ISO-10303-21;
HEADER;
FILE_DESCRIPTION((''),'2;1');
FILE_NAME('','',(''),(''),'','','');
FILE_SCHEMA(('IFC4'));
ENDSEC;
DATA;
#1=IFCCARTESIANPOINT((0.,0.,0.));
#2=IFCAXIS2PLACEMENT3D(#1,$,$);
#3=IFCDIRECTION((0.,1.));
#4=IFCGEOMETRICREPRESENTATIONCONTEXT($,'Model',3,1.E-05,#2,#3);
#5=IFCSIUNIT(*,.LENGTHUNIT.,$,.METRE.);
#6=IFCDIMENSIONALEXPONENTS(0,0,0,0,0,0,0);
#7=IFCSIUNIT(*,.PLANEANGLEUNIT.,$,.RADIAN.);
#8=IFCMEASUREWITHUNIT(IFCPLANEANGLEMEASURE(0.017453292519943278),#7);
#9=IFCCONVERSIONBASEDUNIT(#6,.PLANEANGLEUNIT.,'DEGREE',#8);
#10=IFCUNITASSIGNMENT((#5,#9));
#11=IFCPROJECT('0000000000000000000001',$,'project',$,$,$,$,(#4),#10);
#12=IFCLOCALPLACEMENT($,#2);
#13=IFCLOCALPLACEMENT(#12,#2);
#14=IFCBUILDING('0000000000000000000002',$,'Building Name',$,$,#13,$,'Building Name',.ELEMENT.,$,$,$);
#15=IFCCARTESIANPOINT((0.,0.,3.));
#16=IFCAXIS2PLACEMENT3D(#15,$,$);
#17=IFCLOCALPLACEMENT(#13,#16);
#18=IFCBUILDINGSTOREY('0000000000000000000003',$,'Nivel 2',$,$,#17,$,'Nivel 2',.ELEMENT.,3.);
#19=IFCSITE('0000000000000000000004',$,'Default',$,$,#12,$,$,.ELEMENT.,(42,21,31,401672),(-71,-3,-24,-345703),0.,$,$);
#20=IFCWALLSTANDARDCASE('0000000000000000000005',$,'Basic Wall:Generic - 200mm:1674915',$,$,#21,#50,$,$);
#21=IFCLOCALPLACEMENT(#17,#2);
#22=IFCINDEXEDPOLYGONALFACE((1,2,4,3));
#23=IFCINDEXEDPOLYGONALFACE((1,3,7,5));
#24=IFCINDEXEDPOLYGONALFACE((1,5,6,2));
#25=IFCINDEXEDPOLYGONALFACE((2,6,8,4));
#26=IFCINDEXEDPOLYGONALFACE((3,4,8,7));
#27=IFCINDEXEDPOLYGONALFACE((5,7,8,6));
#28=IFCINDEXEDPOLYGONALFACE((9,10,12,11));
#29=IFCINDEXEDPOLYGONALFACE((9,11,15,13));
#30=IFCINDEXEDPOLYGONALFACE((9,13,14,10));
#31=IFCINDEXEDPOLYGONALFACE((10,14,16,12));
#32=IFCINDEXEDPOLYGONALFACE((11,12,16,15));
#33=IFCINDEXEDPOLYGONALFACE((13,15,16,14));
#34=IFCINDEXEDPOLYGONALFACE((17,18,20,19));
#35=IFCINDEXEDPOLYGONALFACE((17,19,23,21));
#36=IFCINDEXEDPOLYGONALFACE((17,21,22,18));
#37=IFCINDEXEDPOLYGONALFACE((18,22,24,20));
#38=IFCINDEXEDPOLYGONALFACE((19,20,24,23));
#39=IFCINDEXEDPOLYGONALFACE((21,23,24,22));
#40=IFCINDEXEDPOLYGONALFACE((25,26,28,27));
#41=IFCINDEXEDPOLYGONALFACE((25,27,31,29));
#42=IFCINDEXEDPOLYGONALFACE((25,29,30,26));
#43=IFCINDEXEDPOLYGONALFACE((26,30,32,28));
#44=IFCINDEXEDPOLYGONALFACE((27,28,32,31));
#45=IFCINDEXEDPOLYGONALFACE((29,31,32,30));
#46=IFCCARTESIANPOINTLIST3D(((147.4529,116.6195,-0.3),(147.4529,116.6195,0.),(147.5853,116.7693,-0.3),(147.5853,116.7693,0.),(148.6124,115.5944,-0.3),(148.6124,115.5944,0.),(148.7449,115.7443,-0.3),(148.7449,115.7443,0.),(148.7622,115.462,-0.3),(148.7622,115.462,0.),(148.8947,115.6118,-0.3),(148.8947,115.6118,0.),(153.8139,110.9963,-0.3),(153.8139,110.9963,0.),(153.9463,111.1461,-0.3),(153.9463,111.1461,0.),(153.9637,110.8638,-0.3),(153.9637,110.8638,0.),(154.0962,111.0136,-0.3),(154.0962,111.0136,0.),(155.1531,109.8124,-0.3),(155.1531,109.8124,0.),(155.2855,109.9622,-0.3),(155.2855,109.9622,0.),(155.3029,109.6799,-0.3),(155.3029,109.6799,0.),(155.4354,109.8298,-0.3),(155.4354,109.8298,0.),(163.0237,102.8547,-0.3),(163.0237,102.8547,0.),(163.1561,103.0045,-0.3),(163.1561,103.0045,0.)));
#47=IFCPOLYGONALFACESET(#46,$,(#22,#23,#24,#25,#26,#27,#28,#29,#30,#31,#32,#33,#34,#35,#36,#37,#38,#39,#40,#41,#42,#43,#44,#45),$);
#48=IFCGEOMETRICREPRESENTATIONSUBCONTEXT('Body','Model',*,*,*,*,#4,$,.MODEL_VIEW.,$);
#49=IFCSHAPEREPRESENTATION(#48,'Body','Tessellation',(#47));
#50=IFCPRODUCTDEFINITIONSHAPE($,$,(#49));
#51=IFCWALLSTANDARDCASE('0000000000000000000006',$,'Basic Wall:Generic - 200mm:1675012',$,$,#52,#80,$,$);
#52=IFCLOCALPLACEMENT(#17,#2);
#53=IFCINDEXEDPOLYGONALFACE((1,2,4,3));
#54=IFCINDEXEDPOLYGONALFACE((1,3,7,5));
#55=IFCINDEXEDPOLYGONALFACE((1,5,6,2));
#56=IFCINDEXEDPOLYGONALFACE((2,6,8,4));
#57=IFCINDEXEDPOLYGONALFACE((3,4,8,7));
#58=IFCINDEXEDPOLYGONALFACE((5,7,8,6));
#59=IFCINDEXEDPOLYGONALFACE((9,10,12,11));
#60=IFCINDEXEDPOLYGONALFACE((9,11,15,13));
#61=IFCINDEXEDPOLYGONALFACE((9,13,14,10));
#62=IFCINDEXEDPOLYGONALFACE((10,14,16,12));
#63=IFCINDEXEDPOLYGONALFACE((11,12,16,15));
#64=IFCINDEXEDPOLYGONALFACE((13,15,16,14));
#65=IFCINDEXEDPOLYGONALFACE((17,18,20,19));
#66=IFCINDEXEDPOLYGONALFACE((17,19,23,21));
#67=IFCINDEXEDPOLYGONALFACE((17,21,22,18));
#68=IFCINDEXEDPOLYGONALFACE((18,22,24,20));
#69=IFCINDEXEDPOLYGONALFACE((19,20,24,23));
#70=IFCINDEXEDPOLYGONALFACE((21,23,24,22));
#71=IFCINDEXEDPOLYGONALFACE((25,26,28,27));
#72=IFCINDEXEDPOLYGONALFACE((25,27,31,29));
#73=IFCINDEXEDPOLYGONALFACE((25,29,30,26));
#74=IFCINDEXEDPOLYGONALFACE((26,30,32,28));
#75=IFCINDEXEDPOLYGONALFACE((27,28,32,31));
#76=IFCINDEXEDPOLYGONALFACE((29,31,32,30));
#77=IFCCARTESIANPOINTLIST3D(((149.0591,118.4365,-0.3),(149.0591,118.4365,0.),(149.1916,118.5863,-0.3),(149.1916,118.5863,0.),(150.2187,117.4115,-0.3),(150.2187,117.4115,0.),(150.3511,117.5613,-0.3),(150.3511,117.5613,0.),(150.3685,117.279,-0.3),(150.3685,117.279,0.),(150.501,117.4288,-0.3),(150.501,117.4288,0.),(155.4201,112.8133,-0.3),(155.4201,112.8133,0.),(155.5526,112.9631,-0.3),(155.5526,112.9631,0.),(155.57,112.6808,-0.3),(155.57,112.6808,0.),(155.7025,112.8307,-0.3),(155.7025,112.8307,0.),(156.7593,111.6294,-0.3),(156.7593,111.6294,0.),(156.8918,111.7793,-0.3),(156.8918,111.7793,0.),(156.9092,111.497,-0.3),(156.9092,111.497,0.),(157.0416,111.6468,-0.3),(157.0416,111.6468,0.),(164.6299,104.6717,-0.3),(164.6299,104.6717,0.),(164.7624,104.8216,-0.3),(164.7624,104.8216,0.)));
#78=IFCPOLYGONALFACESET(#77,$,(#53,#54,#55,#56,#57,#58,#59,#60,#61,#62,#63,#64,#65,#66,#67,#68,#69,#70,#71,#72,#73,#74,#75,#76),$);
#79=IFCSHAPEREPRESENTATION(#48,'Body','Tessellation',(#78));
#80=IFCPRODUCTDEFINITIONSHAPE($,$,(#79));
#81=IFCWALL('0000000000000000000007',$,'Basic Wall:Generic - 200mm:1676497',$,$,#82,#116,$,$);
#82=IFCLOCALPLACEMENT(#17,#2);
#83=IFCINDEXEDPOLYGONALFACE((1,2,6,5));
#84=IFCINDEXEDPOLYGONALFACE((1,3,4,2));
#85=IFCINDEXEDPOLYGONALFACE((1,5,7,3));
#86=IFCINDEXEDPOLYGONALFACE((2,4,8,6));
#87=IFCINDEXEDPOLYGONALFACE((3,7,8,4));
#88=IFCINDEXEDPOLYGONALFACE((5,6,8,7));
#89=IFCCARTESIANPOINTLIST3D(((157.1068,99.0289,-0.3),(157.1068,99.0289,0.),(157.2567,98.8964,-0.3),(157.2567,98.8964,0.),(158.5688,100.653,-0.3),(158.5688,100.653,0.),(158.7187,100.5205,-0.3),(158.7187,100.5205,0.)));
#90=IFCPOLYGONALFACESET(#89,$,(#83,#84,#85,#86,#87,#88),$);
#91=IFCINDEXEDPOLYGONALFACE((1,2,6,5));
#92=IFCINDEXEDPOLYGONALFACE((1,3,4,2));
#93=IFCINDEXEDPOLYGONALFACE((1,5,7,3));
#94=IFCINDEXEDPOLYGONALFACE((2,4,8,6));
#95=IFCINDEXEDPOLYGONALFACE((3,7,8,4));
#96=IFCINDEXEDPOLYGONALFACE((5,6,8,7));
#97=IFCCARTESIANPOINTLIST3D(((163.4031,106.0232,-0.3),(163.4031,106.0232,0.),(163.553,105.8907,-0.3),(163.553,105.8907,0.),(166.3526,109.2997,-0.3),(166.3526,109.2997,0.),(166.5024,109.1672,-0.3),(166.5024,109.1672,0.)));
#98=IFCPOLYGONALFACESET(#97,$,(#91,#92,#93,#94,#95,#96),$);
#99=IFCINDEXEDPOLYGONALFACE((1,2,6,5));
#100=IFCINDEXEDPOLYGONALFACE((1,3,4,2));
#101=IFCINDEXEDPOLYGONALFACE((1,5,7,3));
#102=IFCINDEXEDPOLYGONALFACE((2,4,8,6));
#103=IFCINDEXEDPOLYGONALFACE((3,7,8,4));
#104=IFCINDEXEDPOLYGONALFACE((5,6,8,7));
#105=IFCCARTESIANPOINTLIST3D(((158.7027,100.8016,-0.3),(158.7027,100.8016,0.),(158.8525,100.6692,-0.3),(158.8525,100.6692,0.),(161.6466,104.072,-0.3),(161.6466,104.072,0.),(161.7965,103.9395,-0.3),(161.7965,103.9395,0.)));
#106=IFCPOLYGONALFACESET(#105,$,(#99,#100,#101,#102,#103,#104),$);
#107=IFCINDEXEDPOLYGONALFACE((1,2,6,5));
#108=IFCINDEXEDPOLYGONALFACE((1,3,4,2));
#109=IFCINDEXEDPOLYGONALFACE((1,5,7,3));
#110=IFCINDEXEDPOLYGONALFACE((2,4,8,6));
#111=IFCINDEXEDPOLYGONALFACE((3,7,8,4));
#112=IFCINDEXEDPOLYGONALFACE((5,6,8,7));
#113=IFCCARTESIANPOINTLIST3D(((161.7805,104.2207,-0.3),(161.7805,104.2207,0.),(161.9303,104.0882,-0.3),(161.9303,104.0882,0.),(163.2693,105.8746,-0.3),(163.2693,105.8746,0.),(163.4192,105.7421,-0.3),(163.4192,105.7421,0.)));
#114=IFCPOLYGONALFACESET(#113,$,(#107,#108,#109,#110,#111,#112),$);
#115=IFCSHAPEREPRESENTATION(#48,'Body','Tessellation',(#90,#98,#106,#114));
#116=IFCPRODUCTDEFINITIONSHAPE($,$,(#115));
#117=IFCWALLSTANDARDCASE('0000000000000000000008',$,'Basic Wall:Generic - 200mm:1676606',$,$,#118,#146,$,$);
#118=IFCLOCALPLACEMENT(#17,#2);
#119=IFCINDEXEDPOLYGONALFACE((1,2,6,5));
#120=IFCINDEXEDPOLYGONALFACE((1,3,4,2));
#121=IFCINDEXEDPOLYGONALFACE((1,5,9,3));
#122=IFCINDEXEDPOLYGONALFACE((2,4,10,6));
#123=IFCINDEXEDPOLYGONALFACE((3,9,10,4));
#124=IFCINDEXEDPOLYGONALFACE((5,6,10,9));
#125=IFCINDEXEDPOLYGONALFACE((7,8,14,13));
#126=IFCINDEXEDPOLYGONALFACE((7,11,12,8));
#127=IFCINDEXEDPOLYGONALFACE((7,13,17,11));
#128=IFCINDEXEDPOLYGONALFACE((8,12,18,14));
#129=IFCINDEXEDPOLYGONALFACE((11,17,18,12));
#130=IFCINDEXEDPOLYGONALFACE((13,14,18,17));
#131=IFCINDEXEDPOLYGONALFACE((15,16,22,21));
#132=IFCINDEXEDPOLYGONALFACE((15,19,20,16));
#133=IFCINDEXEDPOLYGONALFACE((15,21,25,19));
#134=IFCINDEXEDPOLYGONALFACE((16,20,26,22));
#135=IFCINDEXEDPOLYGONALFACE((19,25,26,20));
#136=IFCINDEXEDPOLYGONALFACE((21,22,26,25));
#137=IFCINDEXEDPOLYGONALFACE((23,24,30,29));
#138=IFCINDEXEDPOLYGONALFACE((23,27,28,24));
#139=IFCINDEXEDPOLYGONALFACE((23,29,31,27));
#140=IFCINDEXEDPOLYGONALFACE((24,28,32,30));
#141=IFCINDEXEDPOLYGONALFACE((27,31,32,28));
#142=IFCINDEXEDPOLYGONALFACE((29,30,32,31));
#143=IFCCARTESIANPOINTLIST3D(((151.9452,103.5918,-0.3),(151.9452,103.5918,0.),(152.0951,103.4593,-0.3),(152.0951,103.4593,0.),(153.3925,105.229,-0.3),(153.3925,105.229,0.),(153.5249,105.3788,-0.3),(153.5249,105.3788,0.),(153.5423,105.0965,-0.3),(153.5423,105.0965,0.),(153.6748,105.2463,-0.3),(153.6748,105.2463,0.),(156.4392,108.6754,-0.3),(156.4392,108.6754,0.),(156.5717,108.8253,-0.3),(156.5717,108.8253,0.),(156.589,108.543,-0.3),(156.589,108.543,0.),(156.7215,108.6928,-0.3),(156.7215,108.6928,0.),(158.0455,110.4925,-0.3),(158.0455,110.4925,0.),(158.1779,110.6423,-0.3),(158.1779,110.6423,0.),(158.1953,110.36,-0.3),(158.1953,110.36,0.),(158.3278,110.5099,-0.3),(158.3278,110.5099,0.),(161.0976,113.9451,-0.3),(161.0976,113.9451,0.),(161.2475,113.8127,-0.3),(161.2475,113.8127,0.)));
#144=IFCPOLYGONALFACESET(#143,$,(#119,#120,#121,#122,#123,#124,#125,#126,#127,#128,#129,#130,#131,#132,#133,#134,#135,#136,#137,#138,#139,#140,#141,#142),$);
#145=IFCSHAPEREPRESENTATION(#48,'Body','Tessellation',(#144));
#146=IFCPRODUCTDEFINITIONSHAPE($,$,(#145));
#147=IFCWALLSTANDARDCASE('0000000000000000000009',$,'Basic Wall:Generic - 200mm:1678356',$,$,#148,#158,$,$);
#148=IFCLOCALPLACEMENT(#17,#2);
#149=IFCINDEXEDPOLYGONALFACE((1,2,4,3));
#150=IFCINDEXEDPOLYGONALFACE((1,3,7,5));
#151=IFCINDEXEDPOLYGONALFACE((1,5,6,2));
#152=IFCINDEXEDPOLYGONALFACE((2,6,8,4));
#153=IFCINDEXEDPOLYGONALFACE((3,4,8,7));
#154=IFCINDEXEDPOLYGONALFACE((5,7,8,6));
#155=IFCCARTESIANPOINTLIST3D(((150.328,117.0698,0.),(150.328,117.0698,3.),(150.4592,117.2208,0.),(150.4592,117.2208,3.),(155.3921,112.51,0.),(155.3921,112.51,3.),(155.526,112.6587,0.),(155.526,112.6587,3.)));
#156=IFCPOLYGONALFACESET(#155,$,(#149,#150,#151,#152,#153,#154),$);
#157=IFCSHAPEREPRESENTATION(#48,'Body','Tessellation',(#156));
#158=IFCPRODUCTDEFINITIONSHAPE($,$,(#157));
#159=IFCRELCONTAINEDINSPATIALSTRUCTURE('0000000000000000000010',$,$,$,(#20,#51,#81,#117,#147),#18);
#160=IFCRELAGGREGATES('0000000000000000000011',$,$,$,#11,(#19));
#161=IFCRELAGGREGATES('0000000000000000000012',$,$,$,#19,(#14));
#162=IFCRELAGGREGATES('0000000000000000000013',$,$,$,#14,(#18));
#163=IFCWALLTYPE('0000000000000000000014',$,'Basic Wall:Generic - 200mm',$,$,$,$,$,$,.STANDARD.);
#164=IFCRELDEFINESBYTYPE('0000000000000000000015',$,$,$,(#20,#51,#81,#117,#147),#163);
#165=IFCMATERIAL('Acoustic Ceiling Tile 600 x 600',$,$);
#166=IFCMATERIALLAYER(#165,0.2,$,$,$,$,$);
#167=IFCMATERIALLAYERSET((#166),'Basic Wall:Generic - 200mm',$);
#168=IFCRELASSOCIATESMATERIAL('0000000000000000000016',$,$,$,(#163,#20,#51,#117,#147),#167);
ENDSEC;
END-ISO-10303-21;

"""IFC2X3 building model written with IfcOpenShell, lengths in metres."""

from ifc_helpers import new_model, entity, si_unit, converted_unit, direction, frame, frame_2d, origin, origin_2d_with_axis, place, context, subcontext, project, spatial, polyline, rectangle, outline, extrude, material, layer, layer_set, layer_usage, type_object, element, save


model = new_model("IFC2X3")

# Units and contexts
model_context = context("Model", 3, precision=1e-05, world=origin(), true_north=direction((0.0, 1.0)))
body_context = subcontext(model_context, "Body", "Model", "MODEL_VIEW")
ifc_project = project(units=[si_unit("LENGTHUNIT", "METRE"), converted_unit("PLANEANGLEUNIT", "DEGREE", entity("IfcPlaneAngleMeasure", 0.017453292519943278), si_unit("PLANEANGLEUNIT", "RADIAN"), dimensions=[0, 0, 0, 0, 0, 0, 0])], contexts=[model_context])

# Site, building, storey
site_placement = place(None, origin())
site = spatial("IfcSite", under=ifc_project, at=site_placement, Name="Default", CompositionType="ELEMENT", RefLatitude=(42, 21, 31, 401672), RefLongitude=(-71, -3, -24, -345703), RefElevation=0.0)
building_placement = place(site_placement, origin())
building = spatial("IfcBuilding", under=site, at=building_placement, Name="Building Name", LongName="Building Name", CompositionType="ELEMENT")
storey_placement = place(building_placement, frame((0.0, 0.0, 3.0)))
storey = spatial("IfcBuildingStorey", under=building, at=storey_placement, Name="Nivel 2", LongName="Nivel 2", CompositionType="ELEMENT", Elevation=3.0)

# Shared definitions
ifc_material_1 = material(Name="Acoustic Ceiling Tile 600 x 600")
ifc_layer_1 = layer(ifc_material_1, 0.2)
ifc_layer_set_1 = layer_set([ifc_layer_1], Name="Basic Wall:Generic - 200mm")
wall_type_1 = type_object("IfcWallType", Name="Basic Wall:Generic - 200mm", PredefinedType="STANDARD", material=ifc_layer_set_1)

# Walls, openings
ifc_layer_usage_1 = layer_usage(ifc_layer_set_1, "AXIS2", "NEGATIVE", 0.1)
wall_1_placement = place(storey_placement, frame((163.0899, 102.9296, -0.3), z_axis=(0.0, 0.0, 1.0), x_axis=(-0.749221, 0.66232, 0.0)))
wall_1 = element("IfcWallStandardCase", 1, at=wall_1_placement, inside=storey, type_object=wall_type_1, material=ifc_layer_usage_1, Name="Basic Wall:Generic - 200mm:1674915", context=body_context, shape_type="SweptSolid", body=[
    extrude(rectangle(XDim=20.7826, YDim=0.2, at=frame_2d((10.3913, 0.0), x_axis=(-1.0, 0.0))), origin(), (0.0, 0.0, 1.0), 0.3),
])
opening_1_placement = place(storey_placement, frame((163.0899, 102.9296, -0.3), z_axis=(0.0, 0.0, 1.0), x_axis=(-0.749221, 0.66232, 0.0)))
element("IfcOpeningElement", 2, at=opening_1_placement, cuts=wall_1, ObjectType="Opening", context=body_context, shape_type="SweptSolid", body=[
    extrude(rectangle(XDim=0.3, YDim=0.2, at=origin_2d_with_axis()), frame((10.305, 0.0, 0.15), z_axis=(1.0, 0.0, 0.0), x_axis=(0.0, 0.0, -1.0)), (0.0, 0.0, 1.0), 0.2),
])
opening_2_placement = place(storey_placement, frame((163.0899, 102.9296, -0.3), z_axis=(0.0, 0.0, 1.0), x_axis=(-0.749221, 0.66232, 0.0)))
element("IfcOpeningElement", 3, at=opening_2_placement, cuts=wall_1, ObjectType="Opening", context=body_context, shape_type="SweptSolid", body=[
    extrude(rectangle(XDim=0.3, YDim=0.2, at=frame_2d((0.0, 0.0), x_axis=(1.0, 0.0))), frame((12.0925, 0.0, 0.15), z_axis=(1.0, 0.0, 0.0), x_axis=(0.0, 0.0, -1.0)), (0.0, 0.0, 1.0), 0.2),
])
opening_3_placement = place(storey_placement, frame((163.0899, 102.9296, -0.3), z_axis=(0.0, 0.0, 1.0), x_axis=(-0.749221, 0.66232, 0.0)))
element("IfcOpeningElement", 4, at=opening_3_placement, cuts=wall_1, ObjectType="Opening", context=body_context, shape_type="SweptSolid", body=[
    extrude(rectangle(XDim=0.3, YDim=0.2, at=frame_2d((0.0, 0.0), x_axis=(1.0, 0.0))), frame((19.235, 0.0, 0.15), z_axis=(-1.0, 0.0, 0.0), x_axis=(0.0, 0.0, 1.0)), (0.0, 0.0, 1.0), 0.2),
])
ifc_layer_usage_2 = layer_usage(ifc_layer_set_1, "AXIS2", "NEGATIVE", 0.1)
wall_2_placement = place(storey_placement, frame((164.6962, 104.7467, -0.3), z_axis=(0.0, 0.0, 1.0), x_axis=(-0.749221, 0.66232, 0.0)))
wall_2 = element("IfcWallStandardCase", 5, at=wall_2_placement, inside=storey, type_object=wall_type_1, material=ifc_layer_usage_2, Name="Basic Wall:Generic - 200mm:1675012", context=body_context, shape_type="SweptSolid", body=[
    extrude(rectangle(XDim=20.7826, YDim=0.2, at=frame_2d((10.3913, 0.0), x_axis=(-1.0, 0.0))), origin(), (0.0, 0.0, 1.0), 0.3),
])
opening_4_placement = place(storey_placement, frame((164.6962, 104.7467, -0.3), z_axis=(0.0, 0.0, 1.0), x_axis=(-0.749221, 0.66232, 0.0)))
element("IfcOpeningElement", 6, at=opening_4_placement, cuts=wall_2, ObjectType="Opening", context=body_context, shape_type="SweptSolid", body=[
    extrude(rectangle(XDim=0.3, YDim=0.2, at=frame_2d((0.0, 0.0), x_axis=(1.0, 0.0))), frame((10.305, 0.0, 0.15), z_axis=(1.0, 0.0, 0.0), x_axis=(0.0, 0.0, -1.0)), (0.0, 0.0, 1.0), 0.2),
])
opening_5_placement = place(storey_placement, frame((164.6962, 104.7467, -0.3), z_axis=(0.0, 0.0, 1.0), x_axis=(-0.749221, 0.66232, 0.0)))
element("IfcOpeningElement", 7, at=opening_5_placement, cuts=wall_2, ObjectType="Opening", context=body_context, shape_type="SweptSolid", body=[
    extrude(rectangle(XDim=0.3, YDim=0.2, at=origin_2d_with_axis()), frame((12.0925, 0.0, 0.15), z_axis=(1.0, 0.0, 0.0), x_axis=(0.0, 0.0, -1.0)), (0.0, 0.0, 1.0), 0.2),
])
opening_6_placement = place(storey_placement, frame((164.6962, 104.7467, -0.3), z_axis=(0.0, 0.0, 1.0), x_axis=(-0.749221, 0.66232, 0.0)))
element("IfcOpeningElement", 8, at=opening_6_placement, cuts=wall_2, ObjectType="Opening", context=body_context, shape_type="SweptSolid", body=[
    extrude(rectangle(XDim=0.3, YDim=0.2, at=origin_2d_with_axis()), frame((19.035, 0.0, 0.15), z_axis=(1.0, 0.0, 0.0), x_axis=(0.0, 0.0, -1.0)), (0.0, 0.0, 1.0), 0.2),
])

# Wall
wall_3_placement = place(storey_placement, frame((157.1812, 98.962, -0.3), z_axis=(0.0, 0.0, 1.0), x_axis=(0.669046, 0.743221, 0.0)))
element("IfcWall", 9, at=wall_3_placement, inside=storey, type_object=wall_type_1, Name="Basic Wall:Generic - 200mm:1676497", context=body_context, shape_type="SweptSolid", body=[
    extrude(outline(polyline([(-0.1099, -1.0926), (0.0902, -1.0926), (0.1099, 1.0926), (-0.0902, 1.0926), (-0.1099, -1.0926)])), frame((1.0935, 0.0, 0.0), z_axis=(0.0, 0.0, 1.0), x_axis=(-0.009014, 0.999959, 0.0)), (0.0, 0.0, 1.0), 0.3),
    extrude(outline(polyline([(-2.2033, -0.1), (2.2051, -0.1), (2.2033, 0.1), (-2.2051, 0.1), (-2.2033, -0.1)])), frame((11.616, 0.0, 0.0), z_axis=(0.0, 0.0, 1.0), x_axis=(-1.0, 0.0, 0.0)), (0.0, 0.0, 1.0), 0.3),
    extrude(outline(polyline([(-2.1992, -0.1), (2.201, -0.1), (2.1992, 0.1), (-2.201, 0.1), (-2.1992, -0.1)])), frame((4.5863, 0.0, 0.0)), (0.0, 0.0, 1.0), 0.3),
    extrude(outline(polyline([(-1.1118, -0.1), (1.1136, -0.1), (1.1118, 0.1), (-1.1136, 0.1), (-1.1118, -0.1)])), frame((8.0991, 0.0, 0.0)), (0.0, 0.0, 1.0), 0.3),
])

# Wall, openings
ifc_layer_usage_3 = layer_usage(ifc_layer_set_1, "AXIS2", "NEGATIVE", 0.1)
wall_4_placement = place(storey_placement, frame((152.0201, 103.5256, -0.3), z_axis=(0.0, 0.0, 1.0), x_axis=(0.66232, 0.749221, 0.0)))
wall_4 = element("IfcWallStandardCase", 10, at=wall_4_placement, inside=storey, type_object=wall_type_1, material=ifc_layer_usage_3, Name="Basic Wall:Generic - 200mm:1676606", context=body_context, shape_type="SweptSolid", body=[
    extrude(rectangle(XDim=13.8188, YDim=0.2, at=frame_2d((6.9094, 0.0), x_axis=(-1.0, 0.0))), origin(), (0.0, 0.0, 1.0), 0.3),
])
opening_7_placement = place(storey_placement, frame((152.0201, 103.5256, -0.3), z_axis=(0.0, 0.0, 1.0), x_axis=(0.66232, 0.749221, 0.0)))
element("IfcOpeningElement", 11, at=opening_7_placement, cuts=wall_4, ObjectType="Opening", context=body_context, shape_type="SweptSolid", body=[
    extrude(rectangle(XDim=0.3, YDim=0.2, at=frame_2d((0.0, 0.0), x_axis=(1.0, 0.0))), frame((9.2105, 0.0, 0.15), z_axis=(1.0, 0.0, 0.0), x_axis=(0.0, 0.0, -1.0)), (0.0, 0.0, 1.0), 0.2),
])
opening_8_placement = place(storey_placement, frame((152.0201, 103.5256, -0.3), z_axis=(0.0, 0.0, 1.0), x_axis=(0.66232, 0.749221, 0.0)))
element("IfcOpeningElement", 12, at=opening_8_placement, cuts=wall_4, ObjectType="Opening", context=body_context, shape_type="SweptSolid", body=[
    extrude(rectangle(XDim=0.3, YDim=0.2, at=frame_2d((0.0, 0.0), x_axis=(1.0, 0.0))), frame((6.7852, 0.0, 0.15), z_axis=(1.0, 0.0, 0.0), x_axis=(0.0, 0.0, -1.0)), (0.0, 0.0, 1.0), 0.2),
])
opening_9_placement = place(storey_placement, frame((152.0201, 103.5256, -0.3), z_axis=(0.0, 0.0, 1.0), x_axis=(0.66232, 0.749221, 0.0)))
element("IfcOpeningElement", 13, at=opening_9_placement, cuts=wall_4, ObjectType="Opening", context=body_context, shape_type="SweptSolid", body=[
    extrude(rectangle(XDim=0.3, YDim=0.2, at=origin_2d_with_axis()), frame((2.1851, 0.0, 0.15), z_axis=(1.0, 0.0, 0.0), x_axis=(0.0, 0.0, -1.0)), (0.0, 0.0, 1.0), 0.2),
])

# Wall
ifc_layer_usage_4 = layer_usage(ifc_layer_set_1, "AXIS2", "NEGATIVE", 0.1)
wall_5_placement = place(storey_placement, frame((155.4591, 112.5843, 0.0), z_axis=(0.0, 0.0, 1.0), x_axis=(-0.743145, 0.669131, 0.0)))
element("IfcWallStandardCase", 14, at=wall_5_placement, inside=storey, type_object=wall_type_1, material=ifc_layer_usage_4, Name="Basic Wall:Generic - 200mm:1678356", context=body_context, shape_type="SweptSolid", body=[
    extrude(outline(polyline([(6.8179, -0.1), (6.8145, 0.1), (0.0, 0.1), (0.0, -0.1), (6.8179, -0.1)])), origin(), (0.0, 0.0, 1.0), 3.0),
])

save(model, "model.ifc")
